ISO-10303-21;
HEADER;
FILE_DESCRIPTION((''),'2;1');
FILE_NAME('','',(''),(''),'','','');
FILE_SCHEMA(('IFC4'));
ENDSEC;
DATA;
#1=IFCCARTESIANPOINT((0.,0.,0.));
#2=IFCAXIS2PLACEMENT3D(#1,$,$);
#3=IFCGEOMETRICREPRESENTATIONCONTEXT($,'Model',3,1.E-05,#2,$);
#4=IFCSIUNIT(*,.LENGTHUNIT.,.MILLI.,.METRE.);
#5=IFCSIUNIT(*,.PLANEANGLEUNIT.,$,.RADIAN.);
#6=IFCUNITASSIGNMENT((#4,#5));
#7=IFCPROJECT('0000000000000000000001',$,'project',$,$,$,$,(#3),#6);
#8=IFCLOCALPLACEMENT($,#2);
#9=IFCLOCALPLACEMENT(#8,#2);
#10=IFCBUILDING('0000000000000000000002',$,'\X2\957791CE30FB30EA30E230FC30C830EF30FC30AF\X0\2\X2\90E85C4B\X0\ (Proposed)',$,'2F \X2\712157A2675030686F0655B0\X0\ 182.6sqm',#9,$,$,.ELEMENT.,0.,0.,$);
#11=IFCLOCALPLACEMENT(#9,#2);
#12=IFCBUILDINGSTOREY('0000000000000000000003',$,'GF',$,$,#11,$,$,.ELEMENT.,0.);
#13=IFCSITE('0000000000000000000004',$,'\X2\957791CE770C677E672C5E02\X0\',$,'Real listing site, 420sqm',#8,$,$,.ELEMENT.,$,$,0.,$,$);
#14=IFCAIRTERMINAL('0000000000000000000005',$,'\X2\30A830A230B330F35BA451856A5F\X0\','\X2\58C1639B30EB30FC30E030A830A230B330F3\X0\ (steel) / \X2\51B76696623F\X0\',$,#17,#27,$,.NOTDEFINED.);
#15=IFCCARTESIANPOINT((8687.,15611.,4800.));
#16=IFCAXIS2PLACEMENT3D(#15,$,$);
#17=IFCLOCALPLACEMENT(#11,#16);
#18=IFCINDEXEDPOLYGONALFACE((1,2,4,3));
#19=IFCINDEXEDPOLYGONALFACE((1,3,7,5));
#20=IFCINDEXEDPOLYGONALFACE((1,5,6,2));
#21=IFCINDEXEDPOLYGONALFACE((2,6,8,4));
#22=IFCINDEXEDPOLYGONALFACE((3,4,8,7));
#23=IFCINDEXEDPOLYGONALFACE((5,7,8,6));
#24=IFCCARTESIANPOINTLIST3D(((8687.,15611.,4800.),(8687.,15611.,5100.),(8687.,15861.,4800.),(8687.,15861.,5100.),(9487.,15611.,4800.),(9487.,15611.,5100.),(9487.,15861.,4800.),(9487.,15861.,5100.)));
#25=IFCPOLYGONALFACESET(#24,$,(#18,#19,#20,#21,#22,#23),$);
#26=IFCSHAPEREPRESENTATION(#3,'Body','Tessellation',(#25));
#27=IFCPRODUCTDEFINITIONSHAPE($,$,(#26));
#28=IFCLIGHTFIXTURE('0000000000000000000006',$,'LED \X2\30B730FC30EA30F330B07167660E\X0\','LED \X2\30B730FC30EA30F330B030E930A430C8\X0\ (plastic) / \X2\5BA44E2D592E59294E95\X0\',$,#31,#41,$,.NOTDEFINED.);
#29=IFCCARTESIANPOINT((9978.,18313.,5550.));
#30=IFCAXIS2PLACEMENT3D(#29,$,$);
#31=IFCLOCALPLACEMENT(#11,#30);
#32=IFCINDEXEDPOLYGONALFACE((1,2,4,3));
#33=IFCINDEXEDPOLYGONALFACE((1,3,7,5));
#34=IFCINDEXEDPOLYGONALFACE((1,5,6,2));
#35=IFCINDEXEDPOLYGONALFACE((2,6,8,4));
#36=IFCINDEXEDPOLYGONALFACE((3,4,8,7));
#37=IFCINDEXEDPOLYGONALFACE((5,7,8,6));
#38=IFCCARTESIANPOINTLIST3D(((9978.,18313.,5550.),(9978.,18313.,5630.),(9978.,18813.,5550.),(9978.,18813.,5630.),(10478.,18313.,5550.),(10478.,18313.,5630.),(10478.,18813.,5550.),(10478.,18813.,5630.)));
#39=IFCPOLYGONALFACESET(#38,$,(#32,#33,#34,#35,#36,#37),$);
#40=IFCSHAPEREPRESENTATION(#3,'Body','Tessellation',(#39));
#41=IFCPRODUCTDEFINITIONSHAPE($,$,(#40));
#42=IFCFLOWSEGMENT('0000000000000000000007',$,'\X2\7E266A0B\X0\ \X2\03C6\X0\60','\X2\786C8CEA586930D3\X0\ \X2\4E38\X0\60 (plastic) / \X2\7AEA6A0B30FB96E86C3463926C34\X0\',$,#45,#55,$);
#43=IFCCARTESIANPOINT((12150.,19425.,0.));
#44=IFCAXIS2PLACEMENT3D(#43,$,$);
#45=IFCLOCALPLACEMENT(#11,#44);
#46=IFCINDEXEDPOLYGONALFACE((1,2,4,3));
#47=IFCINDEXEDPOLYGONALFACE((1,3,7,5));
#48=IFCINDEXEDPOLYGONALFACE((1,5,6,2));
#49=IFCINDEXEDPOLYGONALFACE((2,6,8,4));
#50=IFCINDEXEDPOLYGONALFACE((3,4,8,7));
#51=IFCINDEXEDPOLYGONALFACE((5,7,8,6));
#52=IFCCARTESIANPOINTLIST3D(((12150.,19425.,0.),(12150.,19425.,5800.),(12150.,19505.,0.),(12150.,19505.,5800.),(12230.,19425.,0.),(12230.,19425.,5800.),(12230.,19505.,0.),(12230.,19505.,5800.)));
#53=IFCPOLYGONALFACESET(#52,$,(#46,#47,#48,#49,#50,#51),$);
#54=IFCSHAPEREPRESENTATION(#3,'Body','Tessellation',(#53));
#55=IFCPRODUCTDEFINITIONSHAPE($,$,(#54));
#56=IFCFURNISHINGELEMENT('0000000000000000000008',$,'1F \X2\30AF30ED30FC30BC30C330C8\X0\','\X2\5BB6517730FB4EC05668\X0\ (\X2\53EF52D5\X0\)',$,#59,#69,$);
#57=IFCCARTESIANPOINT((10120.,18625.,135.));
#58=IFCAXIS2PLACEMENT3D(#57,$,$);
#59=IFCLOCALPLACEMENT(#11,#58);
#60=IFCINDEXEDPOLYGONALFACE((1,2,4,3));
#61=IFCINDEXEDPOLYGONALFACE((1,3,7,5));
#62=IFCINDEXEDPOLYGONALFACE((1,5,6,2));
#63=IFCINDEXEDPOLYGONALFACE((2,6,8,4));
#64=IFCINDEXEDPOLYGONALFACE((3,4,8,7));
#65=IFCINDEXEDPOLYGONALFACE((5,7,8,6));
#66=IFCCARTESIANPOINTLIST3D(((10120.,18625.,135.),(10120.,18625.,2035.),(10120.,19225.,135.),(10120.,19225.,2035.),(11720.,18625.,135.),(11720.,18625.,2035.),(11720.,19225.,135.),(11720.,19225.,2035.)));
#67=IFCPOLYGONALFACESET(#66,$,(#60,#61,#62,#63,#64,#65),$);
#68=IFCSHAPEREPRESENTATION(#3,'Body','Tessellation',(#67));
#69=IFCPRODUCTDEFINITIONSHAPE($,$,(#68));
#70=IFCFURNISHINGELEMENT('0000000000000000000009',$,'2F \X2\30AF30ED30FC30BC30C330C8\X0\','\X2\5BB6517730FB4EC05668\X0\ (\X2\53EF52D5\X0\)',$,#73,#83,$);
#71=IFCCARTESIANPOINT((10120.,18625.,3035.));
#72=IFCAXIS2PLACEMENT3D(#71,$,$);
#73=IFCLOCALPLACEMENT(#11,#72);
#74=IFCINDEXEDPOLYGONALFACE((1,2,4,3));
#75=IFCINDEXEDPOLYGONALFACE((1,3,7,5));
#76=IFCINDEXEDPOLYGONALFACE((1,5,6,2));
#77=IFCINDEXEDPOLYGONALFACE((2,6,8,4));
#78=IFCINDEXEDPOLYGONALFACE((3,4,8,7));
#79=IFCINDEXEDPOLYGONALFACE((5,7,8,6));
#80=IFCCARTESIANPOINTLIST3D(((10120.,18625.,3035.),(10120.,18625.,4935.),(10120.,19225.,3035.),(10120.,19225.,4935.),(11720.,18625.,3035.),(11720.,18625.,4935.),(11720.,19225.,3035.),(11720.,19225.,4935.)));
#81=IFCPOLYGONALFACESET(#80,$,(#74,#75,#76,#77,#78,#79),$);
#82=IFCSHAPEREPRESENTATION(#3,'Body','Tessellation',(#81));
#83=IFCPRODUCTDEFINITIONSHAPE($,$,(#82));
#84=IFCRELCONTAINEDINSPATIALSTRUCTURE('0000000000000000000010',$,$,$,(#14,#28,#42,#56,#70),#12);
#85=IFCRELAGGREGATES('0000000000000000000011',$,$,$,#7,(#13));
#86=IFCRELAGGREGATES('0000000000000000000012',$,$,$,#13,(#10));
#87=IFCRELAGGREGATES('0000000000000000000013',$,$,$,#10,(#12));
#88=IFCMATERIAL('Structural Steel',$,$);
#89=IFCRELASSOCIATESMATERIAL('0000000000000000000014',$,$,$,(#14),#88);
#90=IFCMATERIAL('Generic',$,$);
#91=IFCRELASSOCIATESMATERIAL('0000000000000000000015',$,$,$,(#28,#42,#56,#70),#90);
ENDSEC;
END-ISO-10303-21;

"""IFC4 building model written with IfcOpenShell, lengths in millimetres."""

from ifc_helpers import new_model, si_unit, frame, frame_2d, origin, place, context, project, spatial, rectangle, extrude, material, element, save


model = new_model("IFC4")

# Units and contexts
model_context = context("Model", 3, precision=1e-05, world=origin())
ifc_project = project(units=[si_unit("LENGTHUNIT", "METRE", prefix="MILLI"), si_unit("PLANEANGLEUNIT", "RADIAN")], contexts=[model_context])

# Site, building, storey
site_placement = place(None, origin())
site = spatial("IfcSite", under=ifc_project, at=site_placement, Name="長野県松本市", ObjectType="Real listing site, 420sqm", CompositionType="ELEMENT", RefElevation=0.0)
building_placement = place(site_placement, origin())
building = spatial("IfcBuilding", under=site, at=building_placement, Name="長野・リモートワーク2部屋 (Proposed)", ObjectType="2F 無垢材と漆喰 182.6sqm", CompositionType="ELEMENT", ElevationOfRefHeight=0.0, ElevationOfTerrain=0.0)
storey_placement = place(building_placement, origin())
storey = spatial("IfcBuildingStorey", under=building, at=storey_placement, Name="GF", CompositionType="ELEMENT", Elevation=0.0)

# Shared definitions
ifc_material_1 = material(Name="Generic")

# Shared definitions
ifc_material_2 = material(Name="Structural Steel")

# Air terminal
air_terminal_1_placement = place(storey_placement, frame((8687.0, 15611.0, 4800.0)))
element("IfcAirTerminal", 1, at=air_terminal_1_placement, inside=storey, material=ifc_material_2, Name="エアコン室内機", Description="壁掛ルームエアコン (steel) / 冷暖房", PredefinedType="NOTDEFINED", context=model_context, shape_type="SweptSolid", body=[
    extrude(rectangle(XDim=800.0, YDim=250.0, at=frame_2d((400.0, 125.0))), frame((8687.0, 15611.0, 4800.0)), (0.0, 0.0, 1.0), 300.0),
])

# Light fixture
light_fixture_1_placement = place(storey_placement, frame((9978.0, 18313.0, 5550.0)))
element("IfcLightFixture", 2, at=light_fixture_1_placement, inside=storey, material=ifc_material_1, Name="LED シーリング照明", Description="LED シーリングライト (plastic) / 室中央天井", PredefinedType="NOTDEFINED", context=model_context, shape_type="SweptSolid", body=[
    extrude(rectangle(XDim=500.0, YDim=500.0, at=frame_2d((250.0, 250.0))), frame((9978.0, 18313.0, 5550.0)), (0.0, 0.0, 1.0), 80.0),
])

# Flow segment
flow_segment_placement = place(storey_placement, frame((12150.0, 19425.0, 0.0)))
element("IfcFlowSegment", 3, at=flow_segment_placement, inside=storey, material=ifc_material_1, Name="縦樋 φ60", Description="硬質塩ビ 丸60 (plastic) / 竪樋・雨水排水", context=model_context, shape_type="SweptSolid", body=[
    extrude(rectangle(XDim=80.0, YDim=80.0, at=frame_2d((40.0, 40.0))), frame((12150.0, 19425.0, 0.0)), (0.0, 0.0, 1.0), 5800.0),
])

# Furnishing elements
furnishing_1_placement = place(storey_placement, frame((10120.0, 18625.0, 135.0)))
element("IfcFurnishingElement", 4, at=furnishing_1_placement, inside=storey, material=ifc_material_1, Name="1F クローゼット", Description="家具・什器 (可動)", context=model_context, shape_type="SweptSolid", body=[
    extrude(rectangle(XDim=1600.0, YDim=600.0, at=frame_2d((800.0, 300.0))), frame((10120.0, 18625.0, 135.0)), (0.0, 0.0, 1.0), 1900.0),
])
furnishing_2_placement = place(storey_placement, frame((10120.0, 18625.0, 3035.0)))
element("IfcFurnishingElement", 5, at=furnishing_2_placement, inside=storey, material=ifc_material_1, Name="2F クローゼット", Description="家具・什器 (可動)", context=model_context, shape_type="SweptSolid", body=[
    extrude(rectangle(XDim=1600.0, YDim=600.0, at=frame_2d((800.0, 300.0))), frame((10120.0, 18625.0, 3035.0)), (0.0, 0.0, 1.0), 1900.0),
])

save(model, "model.ifc")
